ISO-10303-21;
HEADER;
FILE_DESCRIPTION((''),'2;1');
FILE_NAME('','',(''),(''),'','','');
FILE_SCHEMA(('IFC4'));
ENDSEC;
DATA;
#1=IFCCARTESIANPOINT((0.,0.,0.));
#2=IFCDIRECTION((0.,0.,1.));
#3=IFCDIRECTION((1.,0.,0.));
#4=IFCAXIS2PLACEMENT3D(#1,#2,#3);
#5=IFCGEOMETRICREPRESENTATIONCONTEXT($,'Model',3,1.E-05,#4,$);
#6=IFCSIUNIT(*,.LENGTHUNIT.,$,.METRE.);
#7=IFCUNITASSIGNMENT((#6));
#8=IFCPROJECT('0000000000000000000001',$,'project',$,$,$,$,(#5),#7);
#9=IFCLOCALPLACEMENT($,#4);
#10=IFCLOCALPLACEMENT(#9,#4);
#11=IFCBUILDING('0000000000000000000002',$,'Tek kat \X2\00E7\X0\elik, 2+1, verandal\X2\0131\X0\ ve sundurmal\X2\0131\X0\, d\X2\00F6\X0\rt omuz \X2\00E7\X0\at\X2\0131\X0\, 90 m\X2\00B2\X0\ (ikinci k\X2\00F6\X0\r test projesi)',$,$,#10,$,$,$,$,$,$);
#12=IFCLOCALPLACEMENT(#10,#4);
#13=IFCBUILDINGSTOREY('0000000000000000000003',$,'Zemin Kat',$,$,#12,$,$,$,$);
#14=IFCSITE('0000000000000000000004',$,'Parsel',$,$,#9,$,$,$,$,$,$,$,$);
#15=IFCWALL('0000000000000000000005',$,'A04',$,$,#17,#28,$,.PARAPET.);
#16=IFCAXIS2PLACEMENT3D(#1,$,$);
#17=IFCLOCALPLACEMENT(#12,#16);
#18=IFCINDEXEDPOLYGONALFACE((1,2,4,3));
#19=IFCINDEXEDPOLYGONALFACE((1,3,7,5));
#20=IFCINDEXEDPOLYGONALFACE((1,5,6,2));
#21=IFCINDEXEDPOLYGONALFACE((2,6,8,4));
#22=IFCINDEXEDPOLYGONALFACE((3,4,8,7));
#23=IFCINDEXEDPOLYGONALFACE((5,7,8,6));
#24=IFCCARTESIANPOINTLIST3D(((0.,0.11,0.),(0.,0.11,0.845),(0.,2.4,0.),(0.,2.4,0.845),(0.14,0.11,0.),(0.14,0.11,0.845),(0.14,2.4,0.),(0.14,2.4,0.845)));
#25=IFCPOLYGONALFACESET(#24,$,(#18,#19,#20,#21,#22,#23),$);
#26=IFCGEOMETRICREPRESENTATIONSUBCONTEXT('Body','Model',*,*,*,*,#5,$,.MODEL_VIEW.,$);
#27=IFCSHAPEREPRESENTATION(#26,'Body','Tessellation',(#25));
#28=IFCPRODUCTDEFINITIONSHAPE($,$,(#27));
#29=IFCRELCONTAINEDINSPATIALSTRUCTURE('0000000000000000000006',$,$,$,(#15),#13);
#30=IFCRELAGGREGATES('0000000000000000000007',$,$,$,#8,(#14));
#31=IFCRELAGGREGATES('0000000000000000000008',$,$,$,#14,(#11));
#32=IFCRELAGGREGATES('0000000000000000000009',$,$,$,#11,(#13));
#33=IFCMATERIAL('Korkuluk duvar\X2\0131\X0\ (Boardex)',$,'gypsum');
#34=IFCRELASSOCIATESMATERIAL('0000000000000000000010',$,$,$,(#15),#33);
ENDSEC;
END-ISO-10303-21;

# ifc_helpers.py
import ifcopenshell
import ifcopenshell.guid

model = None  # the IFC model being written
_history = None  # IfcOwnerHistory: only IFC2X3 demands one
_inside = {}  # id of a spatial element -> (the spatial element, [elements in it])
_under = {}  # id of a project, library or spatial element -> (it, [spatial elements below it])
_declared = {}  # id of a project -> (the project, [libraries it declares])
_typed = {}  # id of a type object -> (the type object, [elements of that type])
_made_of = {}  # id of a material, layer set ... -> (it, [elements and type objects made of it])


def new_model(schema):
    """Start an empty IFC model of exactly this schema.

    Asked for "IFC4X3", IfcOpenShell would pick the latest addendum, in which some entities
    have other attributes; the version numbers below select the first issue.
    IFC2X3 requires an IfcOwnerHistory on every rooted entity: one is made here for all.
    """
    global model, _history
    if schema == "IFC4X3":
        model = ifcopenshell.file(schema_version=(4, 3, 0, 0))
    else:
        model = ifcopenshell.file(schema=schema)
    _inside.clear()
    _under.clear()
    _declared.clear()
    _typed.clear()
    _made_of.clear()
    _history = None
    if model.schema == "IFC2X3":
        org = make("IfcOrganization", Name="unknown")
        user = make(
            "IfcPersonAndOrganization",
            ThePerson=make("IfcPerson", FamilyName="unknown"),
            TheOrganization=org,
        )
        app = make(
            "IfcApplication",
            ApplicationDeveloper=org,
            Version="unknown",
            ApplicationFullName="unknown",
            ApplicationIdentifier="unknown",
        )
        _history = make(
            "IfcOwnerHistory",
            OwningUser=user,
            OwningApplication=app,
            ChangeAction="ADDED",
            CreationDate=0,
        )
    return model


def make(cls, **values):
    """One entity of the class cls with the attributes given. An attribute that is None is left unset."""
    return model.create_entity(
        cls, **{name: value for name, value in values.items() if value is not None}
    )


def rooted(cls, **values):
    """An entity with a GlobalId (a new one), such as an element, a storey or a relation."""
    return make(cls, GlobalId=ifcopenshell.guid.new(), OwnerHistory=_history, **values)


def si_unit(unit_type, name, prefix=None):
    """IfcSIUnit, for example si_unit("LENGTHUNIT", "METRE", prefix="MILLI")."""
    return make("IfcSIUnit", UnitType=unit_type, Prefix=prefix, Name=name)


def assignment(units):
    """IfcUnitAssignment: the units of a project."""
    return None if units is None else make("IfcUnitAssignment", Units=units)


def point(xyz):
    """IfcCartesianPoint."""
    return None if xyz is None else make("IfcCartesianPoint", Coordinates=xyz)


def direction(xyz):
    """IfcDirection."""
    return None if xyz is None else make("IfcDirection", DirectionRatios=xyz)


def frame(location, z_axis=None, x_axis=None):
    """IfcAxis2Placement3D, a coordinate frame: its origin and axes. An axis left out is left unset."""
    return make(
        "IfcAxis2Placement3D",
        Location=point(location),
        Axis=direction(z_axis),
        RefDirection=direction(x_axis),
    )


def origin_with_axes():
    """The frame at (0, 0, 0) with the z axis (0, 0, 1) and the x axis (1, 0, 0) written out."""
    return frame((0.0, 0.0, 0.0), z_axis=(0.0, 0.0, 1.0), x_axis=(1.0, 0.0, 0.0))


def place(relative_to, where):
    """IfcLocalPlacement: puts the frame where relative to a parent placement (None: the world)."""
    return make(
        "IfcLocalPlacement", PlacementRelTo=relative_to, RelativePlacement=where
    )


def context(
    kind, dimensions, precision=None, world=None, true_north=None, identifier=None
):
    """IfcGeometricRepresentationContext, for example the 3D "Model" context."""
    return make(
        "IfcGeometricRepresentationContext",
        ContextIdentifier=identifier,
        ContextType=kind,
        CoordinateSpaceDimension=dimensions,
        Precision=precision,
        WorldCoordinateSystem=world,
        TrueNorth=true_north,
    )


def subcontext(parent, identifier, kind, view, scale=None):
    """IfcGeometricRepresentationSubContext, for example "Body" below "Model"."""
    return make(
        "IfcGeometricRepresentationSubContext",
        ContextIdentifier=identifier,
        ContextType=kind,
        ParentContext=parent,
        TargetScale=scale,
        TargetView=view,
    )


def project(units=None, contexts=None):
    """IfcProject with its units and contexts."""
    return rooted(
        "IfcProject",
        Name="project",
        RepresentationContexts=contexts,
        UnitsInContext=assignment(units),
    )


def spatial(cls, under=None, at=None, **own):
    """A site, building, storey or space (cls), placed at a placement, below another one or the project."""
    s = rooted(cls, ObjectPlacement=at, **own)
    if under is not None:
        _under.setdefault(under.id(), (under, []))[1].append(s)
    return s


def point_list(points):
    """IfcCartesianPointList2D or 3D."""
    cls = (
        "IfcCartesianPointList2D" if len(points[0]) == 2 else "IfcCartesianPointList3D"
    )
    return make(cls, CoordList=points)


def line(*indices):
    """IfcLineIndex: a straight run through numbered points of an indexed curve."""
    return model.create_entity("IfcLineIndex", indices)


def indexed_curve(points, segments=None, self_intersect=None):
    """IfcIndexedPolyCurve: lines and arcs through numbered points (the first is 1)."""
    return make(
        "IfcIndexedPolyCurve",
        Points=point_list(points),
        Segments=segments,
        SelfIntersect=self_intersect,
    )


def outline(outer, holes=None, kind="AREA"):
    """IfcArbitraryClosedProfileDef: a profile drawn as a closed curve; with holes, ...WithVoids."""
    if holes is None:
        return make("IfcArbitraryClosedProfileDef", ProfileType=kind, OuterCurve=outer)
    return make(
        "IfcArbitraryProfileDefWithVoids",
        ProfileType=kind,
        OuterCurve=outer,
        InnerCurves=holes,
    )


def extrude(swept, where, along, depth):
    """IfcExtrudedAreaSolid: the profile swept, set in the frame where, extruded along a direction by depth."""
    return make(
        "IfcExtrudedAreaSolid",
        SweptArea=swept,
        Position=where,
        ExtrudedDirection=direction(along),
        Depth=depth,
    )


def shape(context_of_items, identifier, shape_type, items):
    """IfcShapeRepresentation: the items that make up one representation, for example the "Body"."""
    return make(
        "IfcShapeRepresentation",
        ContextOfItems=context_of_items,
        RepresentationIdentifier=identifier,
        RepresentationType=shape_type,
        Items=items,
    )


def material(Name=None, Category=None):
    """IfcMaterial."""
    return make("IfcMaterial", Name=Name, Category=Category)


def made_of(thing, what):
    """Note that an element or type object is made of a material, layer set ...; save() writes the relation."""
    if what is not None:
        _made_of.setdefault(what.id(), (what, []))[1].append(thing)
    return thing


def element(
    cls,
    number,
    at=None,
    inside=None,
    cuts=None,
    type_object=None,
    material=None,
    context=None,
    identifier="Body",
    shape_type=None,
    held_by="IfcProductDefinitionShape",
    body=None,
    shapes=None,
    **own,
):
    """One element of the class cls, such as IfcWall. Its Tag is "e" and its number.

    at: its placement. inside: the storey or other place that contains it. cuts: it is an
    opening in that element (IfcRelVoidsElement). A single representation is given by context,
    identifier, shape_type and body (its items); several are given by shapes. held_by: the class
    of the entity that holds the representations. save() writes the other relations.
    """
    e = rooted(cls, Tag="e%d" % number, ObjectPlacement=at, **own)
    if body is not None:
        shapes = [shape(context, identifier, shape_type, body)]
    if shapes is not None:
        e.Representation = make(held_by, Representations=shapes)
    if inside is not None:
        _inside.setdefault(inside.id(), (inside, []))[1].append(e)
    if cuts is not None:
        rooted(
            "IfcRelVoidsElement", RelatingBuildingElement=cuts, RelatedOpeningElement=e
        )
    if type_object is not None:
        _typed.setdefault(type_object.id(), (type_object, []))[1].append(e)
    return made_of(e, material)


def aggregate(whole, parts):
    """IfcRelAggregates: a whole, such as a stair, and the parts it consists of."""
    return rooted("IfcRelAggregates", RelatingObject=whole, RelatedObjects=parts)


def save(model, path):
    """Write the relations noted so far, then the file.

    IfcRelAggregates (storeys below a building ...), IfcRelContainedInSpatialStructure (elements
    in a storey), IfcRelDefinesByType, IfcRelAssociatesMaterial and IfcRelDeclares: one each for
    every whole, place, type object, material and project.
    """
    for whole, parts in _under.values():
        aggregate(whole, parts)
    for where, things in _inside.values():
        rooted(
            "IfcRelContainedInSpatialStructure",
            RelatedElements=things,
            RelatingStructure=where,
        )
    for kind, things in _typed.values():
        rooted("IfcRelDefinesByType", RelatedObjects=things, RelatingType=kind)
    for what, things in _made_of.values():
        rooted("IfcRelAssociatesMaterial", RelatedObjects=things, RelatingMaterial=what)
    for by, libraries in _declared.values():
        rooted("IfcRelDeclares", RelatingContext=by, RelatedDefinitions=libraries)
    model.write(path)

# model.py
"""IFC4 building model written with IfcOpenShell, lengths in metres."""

from ifc_helpers import new_model, si_unit, frame, origin_with_axes, place, context, subcontext, project, spatial, line, indexed_curve, outline, extrude, material, element, save


model = new_model("IFC4")

# Units and contexts
model_context = context("Model", 3, precision=1e-05, world=origin_with_axes())
body_context = subcontext(model_context, "Body", "Model", "MODEL_VIEW")
ifc_project = project(units=[si_unit("LENGTHUNIT", "METRE")], contexts=[model_context])

# Site, building, storey
site_placement = place(None, origin_with_axes())
site = spatial("IfcSite", under=ifc_project, at=site_placement, Name="Parsel")
building_placement = place(site_placement, origin_with_axes())
building = spatial("IfcBuilding", under=site, at=building_placement, Name="Tek kat çelik, 2+1, verandalı ve sundurmalı, dört omuz çatı, 90 m² (ikinci kör test projesi)")
storey_placement = place(building_placement, origin_with_axes())
storey = spatial("IfcBuildingStorey", under=building, at=storey_placement, Name="Zemin Kat")

# Wall
ifc_material_1 = material(Name="Korkuluk duvarı (Boardex)", Category="gypsum")
wall_1_placement = place(storey_placement, origin_with_axes())
element("IfcWall", 1, at=wall_1_placement, inside=storey, material=ifc_material_1, Name="A04", PredefinedType="PARAPET", context=body_context, shape_type="SweptSolid", body=[
    extrude(outline(indexed_curve([(0.0, 0.0), (0.14, 0.0), (0.14, 2.29), (0.0, 2.29)], segments=[line(1, 2, 3, 4, 1)])), frame((0.0, 0.11, 0.0), z_axis=(0.0, 0.0, 1.0), x_axis=(1.0, 0.0, 0.0)), (0.0, 0.0, 1.0), 0.845),
])

save(model, "model.ifc")
